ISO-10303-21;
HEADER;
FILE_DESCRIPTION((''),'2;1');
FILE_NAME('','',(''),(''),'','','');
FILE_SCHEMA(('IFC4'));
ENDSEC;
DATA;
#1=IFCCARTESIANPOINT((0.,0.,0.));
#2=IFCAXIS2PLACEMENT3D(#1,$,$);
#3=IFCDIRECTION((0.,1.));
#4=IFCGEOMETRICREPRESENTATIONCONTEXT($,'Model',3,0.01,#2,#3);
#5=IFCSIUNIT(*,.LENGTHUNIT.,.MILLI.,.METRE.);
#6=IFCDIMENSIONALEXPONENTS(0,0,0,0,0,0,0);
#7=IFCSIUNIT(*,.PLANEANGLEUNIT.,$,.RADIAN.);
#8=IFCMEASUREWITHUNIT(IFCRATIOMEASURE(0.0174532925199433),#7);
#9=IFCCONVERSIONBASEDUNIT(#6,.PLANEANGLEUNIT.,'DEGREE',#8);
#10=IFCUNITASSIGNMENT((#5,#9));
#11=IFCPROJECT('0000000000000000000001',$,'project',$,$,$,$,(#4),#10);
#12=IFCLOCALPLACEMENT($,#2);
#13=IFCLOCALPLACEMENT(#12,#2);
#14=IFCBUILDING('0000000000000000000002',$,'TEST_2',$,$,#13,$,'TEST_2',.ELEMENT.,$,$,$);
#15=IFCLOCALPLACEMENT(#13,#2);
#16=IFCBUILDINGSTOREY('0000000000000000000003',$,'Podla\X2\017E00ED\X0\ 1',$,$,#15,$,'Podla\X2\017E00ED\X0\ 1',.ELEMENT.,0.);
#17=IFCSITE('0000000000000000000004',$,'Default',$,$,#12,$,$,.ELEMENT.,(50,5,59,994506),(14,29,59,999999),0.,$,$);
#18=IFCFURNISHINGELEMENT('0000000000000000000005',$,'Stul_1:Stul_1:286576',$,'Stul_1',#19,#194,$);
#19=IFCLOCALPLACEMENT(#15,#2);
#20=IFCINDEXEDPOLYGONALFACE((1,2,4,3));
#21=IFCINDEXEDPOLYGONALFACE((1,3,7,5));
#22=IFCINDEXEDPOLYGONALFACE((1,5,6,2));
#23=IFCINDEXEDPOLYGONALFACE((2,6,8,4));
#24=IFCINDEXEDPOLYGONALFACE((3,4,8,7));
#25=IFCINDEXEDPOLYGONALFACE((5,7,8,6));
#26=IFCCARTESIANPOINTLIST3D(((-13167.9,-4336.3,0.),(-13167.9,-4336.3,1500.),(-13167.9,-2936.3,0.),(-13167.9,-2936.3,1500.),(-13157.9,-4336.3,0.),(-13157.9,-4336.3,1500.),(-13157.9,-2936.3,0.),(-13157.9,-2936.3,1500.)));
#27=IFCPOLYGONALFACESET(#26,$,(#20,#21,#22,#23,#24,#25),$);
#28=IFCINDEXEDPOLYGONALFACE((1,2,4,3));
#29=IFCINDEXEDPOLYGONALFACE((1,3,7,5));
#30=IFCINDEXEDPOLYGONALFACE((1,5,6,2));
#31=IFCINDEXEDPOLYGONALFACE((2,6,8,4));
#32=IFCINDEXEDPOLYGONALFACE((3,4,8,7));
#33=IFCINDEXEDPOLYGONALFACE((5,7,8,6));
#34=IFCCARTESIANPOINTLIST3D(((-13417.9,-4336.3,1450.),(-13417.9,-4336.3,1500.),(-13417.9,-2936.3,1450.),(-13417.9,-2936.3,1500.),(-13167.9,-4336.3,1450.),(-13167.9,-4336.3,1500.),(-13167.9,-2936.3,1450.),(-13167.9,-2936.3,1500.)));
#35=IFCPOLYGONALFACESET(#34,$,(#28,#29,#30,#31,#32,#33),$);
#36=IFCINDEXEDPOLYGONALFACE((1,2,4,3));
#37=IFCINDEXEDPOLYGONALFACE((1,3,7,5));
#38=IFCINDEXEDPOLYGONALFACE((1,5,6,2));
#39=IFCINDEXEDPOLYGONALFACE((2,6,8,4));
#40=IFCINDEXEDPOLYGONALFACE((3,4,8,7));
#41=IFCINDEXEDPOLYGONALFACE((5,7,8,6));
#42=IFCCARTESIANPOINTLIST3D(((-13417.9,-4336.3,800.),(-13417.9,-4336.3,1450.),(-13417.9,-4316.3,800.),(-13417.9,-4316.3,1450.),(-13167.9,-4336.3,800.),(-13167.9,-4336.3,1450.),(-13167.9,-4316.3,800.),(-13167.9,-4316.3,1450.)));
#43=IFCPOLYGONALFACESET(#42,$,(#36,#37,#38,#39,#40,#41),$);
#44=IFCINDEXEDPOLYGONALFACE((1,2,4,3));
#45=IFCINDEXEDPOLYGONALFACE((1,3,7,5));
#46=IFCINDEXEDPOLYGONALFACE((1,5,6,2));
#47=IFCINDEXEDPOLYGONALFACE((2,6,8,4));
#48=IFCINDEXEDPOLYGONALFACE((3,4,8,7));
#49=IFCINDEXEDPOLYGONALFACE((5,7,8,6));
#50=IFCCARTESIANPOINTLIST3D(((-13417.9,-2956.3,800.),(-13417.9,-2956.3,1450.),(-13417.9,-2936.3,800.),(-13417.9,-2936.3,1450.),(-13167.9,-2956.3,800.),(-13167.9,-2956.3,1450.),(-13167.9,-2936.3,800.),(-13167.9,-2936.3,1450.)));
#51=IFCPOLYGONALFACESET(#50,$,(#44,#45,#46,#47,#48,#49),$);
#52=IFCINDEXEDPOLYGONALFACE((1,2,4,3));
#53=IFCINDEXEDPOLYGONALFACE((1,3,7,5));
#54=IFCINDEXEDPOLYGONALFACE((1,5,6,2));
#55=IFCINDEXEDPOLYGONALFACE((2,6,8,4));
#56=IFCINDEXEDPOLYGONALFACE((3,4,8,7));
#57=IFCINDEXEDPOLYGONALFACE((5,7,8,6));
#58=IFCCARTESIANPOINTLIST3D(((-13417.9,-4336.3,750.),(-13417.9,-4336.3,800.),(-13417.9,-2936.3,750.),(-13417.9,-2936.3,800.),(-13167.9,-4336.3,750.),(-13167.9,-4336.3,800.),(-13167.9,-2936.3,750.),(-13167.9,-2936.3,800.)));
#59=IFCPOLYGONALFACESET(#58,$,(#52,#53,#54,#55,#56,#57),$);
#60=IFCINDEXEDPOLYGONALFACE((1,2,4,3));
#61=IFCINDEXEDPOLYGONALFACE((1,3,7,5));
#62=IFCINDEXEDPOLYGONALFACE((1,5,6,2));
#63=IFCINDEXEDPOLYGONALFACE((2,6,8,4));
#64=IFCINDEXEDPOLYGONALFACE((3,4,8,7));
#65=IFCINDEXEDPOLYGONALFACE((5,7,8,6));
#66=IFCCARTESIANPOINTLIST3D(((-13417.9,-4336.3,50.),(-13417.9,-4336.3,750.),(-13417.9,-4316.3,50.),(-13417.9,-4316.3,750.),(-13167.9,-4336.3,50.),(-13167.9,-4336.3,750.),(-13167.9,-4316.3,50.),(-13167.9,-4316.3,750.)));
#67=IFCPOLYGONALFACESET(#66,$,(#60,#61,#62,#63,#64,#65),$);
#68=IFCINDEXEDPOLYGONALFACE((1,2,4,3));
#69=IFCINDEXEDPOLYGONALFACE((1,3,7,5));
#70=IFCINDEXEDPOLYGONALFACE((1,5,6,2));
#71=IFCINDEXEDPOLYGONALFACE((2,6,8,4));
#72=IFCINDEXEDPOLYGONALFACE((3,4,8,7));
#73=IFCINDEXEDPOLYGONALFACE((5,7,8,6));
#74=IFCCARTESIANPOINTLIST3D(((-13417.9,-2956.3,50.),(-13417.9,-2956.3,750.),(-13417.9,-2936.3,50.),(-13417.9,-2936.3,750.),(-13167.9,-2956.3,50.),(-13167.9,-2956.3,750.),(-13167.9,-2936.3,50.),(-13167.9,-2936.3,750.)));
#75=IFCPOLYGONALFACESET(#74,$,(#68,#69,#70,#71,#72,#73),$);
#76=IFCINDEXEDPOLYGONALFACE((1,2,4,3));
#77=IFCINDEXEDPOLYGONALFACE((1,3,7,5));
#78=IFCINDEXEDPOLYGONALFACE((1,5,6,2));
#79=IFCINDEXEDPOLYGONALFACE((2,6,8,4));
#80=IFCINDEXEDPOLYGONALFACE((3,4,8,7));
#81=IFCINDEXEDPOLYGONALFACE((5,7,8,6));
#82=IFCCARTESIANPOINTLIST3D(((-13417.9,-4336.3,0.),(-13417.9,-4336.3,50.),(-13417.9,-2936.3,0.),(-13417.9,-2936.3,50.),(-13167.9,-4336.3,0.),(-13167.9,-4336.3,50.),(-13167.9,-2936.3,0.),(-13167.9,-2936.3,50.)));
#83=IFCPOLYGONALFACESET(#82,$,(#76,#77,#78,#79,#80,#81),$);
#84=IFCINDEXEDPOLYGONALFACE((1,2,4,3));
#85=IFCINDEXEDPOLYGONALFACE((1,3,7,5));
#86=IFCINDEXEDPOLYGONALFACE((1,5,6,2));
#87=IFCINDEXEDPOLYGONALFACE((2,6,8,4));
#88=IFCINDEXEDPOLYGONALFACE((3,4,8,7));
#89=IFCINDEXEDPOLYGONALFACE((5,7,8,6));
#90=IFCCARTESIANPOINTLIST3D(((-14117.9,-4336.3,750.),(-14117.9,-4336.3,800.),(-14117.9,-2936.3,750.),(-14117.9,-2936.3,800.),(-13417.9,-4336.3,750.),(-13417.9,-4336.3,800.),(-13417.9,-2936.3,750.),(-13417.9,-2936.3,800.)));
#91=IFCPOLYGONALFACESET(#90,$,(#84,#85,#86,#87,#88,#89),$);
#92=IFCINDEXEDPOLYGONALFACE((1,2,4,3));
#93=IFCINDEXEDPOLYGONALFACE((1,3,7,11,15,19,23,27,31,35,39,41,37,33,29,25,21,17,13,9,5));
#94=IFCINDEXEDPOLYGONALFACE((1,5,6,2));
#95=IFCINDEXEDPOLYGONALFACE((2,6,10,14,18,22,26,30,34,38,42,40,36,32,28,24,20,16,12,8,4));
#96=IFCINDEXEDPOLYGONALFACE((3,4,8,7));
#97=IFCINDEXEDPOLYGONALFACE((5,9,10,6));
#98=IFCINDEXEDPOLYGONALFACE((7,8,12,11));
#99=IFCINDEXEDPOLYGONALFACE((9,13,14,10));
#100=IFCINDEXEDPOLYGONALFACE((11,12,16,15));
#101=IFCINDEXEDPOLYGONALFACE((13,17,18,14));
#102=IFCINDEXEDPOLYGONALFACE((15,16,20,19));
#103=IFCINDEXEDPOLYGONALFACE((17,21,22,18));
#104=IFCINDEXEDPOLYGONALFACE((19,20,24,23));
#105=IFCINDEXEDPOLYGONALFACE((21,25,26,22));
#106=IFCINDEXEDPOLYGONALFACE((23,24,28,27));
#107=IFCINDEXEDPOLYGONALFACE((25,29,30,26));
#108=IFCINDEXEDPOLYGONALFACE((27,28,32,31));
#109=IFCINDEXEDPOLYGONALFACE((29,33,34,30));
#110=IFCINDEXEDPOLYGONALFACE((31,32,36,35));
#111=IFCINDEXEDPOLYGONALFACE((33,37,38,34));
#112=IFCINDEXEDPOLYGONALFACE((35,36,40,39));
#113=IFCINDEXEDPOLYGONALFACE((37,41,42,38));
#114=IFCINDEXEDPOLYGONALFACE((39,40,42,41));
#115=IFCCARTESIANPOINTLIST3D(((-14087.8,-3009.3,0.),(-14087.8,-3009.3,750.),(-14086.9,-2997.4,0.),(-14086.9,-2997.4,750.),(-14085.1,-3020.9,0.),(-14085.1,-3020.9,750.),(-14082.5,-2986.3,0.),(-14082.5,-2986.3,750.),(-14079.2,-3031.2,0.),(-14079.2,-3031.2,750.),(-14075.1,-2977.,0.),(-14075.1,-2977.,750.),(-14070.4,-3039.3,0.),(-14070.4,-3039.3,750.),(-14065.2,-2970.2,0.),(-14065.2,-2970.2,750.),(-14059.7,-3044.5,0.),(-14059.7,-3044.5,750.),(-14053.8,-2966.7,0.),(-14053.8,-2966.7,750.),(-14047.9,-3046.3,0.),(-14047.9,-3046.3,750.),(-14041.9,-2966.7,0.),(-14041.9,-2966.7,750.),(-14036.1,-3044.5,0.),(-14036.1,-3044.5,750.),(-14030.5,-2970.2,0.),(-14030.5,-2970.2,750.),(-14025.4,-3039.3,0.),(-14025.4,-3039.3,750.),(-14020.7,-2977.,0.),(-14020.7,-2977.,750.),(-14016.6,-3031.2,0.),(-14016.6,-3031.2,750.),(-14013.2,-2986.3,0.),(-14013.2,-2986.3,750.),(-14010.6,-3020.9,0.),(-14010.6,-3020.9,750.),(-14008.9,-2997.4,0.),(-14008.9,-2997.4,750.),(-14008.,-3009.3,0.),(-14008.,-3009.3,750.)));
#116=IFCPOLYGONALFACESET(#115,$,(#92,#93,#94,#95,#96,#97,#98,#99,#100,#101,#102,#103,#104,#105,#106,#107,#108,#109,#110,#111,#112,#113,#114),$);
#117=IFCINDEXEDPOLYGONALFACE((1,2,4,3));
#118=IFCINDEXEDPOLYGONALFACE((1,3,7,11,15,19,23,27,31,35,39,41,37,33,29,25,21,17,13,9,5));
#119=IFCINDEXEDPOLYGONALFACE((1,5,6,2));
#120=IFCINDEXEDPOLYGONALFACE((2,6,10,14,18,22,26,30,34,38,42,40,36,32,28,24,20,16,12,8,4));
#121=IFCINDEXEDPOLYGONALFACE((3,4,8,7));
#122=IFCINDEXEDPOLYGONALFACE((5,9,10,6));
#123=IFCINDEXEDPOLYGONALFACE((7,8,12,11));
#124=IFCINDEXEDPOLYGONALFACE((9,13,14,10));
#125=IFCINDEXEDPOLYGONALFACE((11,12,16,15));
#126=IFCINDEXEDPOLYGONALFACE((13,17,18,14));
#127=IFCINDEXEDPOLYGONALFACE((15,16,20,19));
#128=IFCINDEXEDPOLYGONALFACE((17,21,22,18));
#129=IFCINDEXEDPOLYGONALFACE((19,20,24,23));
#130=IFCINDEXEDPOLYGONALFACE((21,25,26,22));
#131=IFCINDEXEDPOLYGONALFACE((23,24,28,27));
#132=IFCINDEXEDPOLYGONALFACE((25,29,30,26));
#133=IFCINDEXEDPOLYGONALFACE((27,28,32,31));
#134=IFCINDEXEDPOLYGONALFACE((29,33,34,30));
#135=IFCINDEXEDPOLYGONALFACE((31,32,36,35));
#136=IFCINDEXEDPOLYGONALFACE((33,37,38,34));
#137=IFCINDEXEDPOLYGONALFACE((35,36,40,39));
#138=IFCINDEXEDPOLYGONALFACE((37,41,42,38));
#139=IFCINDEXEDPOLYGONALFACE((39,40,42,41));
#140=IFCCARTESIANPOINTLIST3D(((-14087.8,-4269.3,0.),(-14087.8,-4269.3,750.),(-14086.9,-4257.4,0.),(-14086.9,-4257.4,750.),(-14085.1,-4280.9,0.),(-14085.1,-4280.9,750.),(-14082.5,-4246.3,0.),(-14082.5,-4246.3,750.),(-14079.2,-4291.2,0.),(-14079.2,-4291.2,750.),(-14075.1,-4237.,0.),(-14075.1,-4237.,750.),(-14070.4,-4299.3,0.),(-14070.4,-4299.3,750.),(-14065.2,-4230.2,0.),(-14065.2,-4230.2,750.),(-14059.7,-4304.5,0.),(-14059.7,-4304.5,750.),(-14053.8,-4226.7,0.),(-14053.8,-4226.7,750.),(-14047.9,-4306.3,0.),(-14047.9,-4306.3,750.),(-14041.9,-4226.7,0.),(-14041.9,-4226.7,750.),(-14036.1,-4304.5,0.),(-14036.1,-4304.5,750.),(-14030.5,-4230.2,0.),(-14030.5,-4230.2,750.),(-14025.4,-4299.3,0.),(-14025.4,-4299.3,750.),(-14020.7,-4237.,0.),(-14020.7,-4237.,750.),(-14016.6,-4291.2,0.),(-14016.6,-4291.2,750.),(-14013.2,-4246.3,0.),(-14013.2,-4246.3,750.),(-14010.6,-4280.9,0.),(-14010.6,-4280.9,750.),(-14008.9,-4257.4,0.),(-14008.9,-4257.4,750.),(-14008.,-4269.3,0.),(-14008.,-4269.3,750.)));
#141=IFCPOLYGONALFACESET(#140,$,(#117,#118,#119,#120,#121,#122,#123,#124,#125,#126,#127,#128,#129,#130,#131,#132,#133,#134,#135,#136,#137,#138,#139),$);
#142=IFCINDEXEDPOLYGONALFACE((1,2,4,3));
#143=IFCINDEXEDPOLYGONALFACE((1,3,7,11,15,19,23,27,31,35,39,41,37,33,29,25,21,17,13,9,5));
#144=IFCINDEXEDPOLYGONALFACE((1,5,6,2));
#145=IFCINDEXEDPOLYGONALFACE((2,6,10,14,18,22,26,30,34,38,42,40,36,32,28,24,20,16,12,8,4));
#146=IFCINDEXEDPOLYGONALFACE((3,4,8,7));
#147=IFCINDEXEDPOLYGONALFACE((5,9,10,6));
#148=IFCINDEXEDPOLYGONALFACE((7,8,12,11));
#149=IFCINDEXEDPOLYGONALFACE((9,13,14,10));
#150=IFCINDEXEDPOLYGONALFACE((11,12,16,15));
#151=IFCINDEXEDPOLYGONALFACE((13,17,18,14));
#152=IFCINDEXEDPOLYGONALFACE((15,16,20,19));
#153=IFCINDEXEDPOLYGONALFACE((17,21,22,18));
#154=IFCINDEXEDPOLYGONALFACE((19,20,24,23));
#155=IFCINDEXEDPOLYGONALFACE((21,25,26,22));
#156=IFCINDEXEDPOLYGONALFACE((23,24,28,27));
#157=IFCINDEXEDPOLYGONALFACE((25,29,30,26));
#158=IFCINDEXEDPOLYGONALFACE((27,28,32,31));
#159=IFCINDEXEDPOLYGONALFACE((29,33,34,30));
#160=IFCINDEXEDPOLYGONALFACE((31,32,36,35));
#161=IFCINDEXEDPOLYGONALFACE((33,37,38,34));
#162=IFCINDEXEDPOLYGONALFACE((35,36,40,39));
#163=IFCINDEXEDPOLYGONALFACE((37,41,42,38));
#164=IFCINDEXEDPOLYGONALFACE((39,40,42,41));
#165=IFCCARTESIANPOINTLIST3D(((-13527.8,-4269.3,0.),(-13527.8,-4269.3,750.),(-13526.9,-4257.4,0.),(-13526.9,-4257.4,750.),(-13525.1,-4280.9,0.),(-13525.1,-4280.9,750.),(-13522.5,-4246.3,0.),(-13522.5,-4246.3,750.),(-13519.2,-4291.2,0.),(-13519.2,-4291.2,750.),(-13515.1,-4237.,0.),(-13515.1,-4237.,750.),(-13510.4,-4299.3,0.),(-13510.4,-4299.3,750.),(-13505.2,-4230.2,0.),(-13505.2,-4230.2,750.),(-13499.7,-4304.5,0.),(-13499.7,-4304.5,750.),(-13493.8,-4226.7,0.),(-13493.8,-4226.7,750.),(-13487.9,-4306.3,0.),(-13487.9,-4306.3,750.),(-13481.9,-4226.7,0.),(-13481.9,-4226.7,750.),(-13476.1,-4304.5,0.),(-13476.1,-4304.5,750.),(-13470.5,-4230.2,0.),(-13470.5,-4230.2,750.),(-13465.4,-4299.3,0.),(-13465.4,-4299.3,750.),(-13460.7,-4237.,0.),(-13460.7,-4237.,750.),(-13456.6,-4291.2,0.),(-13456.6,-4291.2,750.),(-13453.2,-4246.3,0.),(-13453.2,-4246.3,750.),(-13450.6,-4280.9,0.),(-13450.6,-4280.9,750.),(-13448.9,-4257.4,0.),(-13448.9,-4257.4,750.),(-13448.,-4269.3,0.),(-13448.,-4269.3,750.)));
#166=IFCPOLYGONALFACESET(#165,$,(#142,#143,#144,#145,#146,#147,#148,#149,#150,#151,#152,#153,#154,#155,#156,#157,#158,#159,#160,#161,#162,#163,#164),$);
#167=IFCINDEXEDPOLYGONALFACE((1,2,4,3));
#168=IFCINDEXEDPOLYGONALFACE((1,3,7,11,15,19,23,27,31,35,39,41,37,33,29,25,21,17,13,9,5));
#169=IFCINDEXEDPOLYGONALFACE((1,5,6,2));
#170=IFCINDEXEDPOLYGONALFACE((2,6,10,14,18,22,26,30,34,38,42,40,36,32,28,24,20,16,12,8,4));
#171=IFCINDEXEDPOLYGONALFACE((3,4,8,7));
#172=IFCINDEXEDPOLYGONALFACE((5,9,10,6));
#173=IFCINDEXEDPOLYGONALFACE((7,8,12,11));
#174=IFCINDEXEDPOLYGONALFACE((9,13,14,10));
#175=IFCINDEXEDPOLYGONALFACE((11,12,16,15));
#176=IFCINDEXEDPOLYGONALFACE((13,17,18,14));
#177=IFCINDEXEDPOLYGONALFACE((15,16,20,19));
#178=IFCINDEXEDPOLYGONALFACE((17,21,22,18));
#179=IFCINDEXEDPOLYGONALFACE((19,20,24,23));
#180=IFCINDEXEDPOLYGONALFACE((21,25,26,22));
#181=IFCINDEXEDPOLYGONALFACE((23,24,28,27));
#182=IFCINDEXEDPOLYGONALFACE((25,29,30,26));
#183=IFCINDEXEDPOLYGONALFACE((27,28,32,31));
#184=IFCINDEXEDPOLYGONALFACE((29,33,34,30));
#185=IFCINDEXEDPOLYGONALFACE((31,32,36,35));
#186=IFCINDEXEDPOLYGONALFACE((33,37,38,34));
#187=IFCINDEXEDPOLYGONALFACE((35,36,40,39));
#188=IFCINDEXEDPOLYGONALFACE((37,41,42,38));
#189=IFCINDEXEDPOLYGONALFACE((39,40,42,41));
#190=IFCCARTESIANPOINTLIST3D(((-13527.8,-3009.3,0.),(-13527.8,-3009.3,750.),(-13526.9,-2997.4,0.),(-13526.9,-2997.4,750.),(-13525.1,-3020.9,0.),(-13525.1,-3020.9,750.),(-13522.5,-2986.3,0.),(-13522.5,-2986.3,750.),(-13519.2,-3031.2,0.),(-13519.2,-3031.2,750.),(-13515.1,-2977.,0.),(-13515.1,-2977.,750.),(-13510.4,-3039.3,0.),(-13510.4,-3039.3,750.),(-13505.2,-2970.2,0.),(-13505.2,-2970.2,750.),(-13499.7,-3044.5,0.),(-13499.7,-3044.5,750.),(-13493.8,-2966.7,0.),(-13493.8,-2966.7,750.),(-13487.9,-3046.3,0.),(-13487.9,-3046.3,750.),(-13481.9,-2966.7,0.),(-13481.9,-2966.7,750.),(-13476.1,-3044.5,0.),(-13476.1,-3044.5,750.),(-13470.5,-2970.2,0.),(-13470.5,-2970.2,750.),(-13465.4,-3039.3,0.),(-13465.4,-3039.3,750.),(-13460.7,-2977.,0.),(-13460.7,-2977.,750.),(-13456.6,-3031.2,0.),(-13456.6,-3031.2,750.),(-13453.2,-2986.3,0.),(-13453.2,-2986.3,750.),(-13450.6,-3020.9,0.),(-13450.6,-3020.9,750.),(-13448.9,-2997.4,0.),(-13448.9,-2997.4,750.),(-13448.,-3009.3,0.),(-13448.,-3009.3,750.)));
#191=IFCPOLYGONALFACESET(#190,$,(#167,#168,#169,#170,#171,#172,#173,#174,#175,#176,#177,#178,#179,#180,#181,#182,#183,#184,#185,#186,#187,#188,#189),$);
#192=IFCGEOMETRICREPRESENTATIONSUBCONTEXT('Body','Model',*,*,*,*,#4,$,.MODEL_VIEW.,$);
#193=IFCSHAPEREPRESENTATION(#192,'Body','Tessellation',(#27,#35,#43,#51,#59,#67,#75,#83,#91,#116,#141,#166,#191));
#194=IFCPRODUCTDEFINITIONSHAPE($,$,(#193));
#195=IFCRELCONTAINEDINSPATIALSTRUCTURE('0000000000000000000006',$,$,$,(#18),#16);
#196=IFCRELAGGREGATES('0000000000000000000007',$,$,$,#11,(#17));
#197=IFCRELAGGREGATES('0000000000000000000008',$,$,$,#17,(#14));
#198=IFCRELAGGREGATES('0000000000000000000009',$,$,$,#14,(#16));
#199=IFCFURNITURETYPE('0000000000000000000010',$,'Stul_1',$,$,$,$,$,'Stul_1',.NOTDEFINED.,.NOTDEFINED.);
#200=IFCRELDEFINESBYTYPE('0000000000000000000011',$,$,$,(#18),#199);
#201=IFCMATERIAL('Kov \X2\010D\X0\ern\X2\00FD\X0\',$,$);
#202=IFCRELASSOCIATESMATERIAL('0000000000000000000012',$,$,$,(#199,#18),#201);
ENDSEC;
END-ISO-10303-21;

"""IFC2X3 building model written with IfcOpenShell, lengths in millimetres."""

from ifc_helpers import new_model, entity, si_unit, converted_unit, direction, frame, frame_2d, origin, origin_2d_with_axis, place, context, subcontext, project, spatial, rectangle, circle, extrude, source, transform, mapped, material, type_object, type_shapes, element, save


model = new_model("IFC2X3")

# Units and contexts
model_context = context("Model", 3, precision=0.01, world=origin(), true_north=direction((0.0, 1.0)))
body_context = subcontext(model_context, "Body", "Model", "MODEL_VIEW")
ifc_project = project(units=[si_unit("LENGTHUNIT", "METRE", prefix="MILLI"), converted_unit("PLANEANGLEUNIT", "DEGREE", entity("IfcRatioMeasure", 0.0174532925199433), si_unit("PLANEANGLEUNIT", "RADIAN"), dimensions=[0, 0, 0, 0, 0, 0, 0])], contexts=[model_context])

# Site, building, storey
site_placement = place(None, origin())
site = spatial("IfcSite", under=ifc_project, at=site_placement, Name="Default", CompositionType="ELEMENT", RefLatitude=(50, 5, 59, 994506), RefLongitude=(14, 29, 59, 999999), RefElevation=0.0)
building_placement = place(site_placement, origin())
building = spatial("IfcBuilding", under=site, at=building_placement, Name="TEST_2", LongName="TEST_2", CompositionType="ELEMENT")
storey_placement = place(building_placement, origin())
storey = spatial("IfcBuildingStorey", under=building, at=storey_placement, Name="Podlaží 1", LongName="Podlaží 1", CompositionType="ELEMENT", Elevation=0.0)

# Furnishing element
ifc_material_1 = material(Name="Kov černý")
furniture_type = type_object("IfcFurnitureType", Name="Stul_1", ElementType="Stul_1", material=ifc_material_1)
shared_shape_1 = source(origin(), body_context, "Body", "SweptSolid", [
    extrude(rectangle(XDim=1400.0, YDim=10.0, at=origin_2d_with_axis()), frame((0.0, 605.0, 0.0), z_axis=(0.0, 0.0, 1.0), x_axis=(-1.0, 0.0, 0.0)), (0.0, 0.0, 1.0), 1500.0),
    extrude(rectangle(XDim=1400.0, YDim=250.0, at=frame_2d((0.0, 0.0), x_axis=(1.0, 0.0))), frame((0.0, 475.0, 1450.0), z_axis=(0.0, 0.0, 1.0), x_axis=(-1.0, 0.0, 0.0)), (0.0, 0.0, 1.0), 50.0),
    extrude(rectangle(XDim=20.0, YDim=250.0, at=origin_2d_with_axis()), frame((690.0, 475.0, 800.0), z_axis=(0.0, 0.0, 1.0), x_axis=(-1.0, 0.0, 0.0)), (0.0, 0.0, 1.0), 650.0),
    extrude(rectangle(XDim=20.0, YDim=250.0, at=frame_2d((0.0, 0.0), x_axis=(1.0, 0.0))), frame((-690.0, 475.0, 800.0), z_axis=(0.0, 0.0, 1.0), x_axis=(-1.0, 0.0, 0.0)), (0.0, 0.0, 1.0), 650.0),
    extrude(rectangle(XDim=1400.0, YDim=250.0, at=origin_2d_with_axis()), frame((0.0, 475.0, 750.0), z_axis=(0.0, 0.0, 1.0), x_axis=(-1.0, 0.0, 0.0)), (0.0, 0.0, 1.0), 50.0),
    extrude(rectangle(XDim=20.0, YDim=250.0, at=origin_2d_with_axis()), frame((690.0, 475.0, 50.0), z_axis=(0.0, 0.0, 1.0), x_axis=(-1.0, 0.0, 0.0)), (0.0, 0.0, 1.0), 700.0),
    extrude(rectangle(XDim=20.0, YDim=250.0, at=frame_2d((0.0, 0.0), x_axis=(1.0, 0.0))), frame((-690.0, 475.0, 50.0), z_axis=(0.0, 0.0, 1.0), x_axis=(-1.0, 0.0, 0.0)), (0.0, 0.0, 1.0), 700.0),
    extrude(rectangle(XDim=1400.0, YDim=250.0, at=origin_2d_with_axis()), frame((0.0, 475.0, 0.0), z_axis=(0.0, 0.0, 1.0), x_axis=(-1.0, 0.0, 0.0)), (0.0, 0.0, 1.0), 50.0),
    extrude(rectangle(XDim=1400.0, YDim=700.0, at=origin_2d_with_axis()), frame((0.0, 0.0, 750.0), z_axis=(0.0, 0.0, 1.0), x_axis=(-1.0, 0.0, 0.0)), (0.0, 0.0, 1.0), 50.0),
    extrude(circle(Radius=40.0, at=frame_2d((0.0, 0.0), x_axis=(1.0, 0.0))), frame((-630.0, -280.0, 0.0)), (0.0, 0.0, 1.0), 750.0),
    extrude(circle(Radius=40.0, at=frame_2d((0.0, 0.0), x_axis=(1.0, 0.0))), frame((630.0, -280.0, 0.0)), (0.0, 0.0, 1.0), 750.0),
    extrude(circle(Radius=40.0, at=frame_2d((0.0, 0.0), x_axis=(1.0, 0.0))), frame((630.0, 280.0, 0.0)), (0.0, 0.0, 1.0), 750.0),
    extrude(circle(Radius=40.0, at=frame_2d((0.0, 0.0), x_axis=(1.0, 0.0))), frame((-630.0, 280.0, 0.0)), (0.0, 0.0, 1.0), 750.0),
])
type_shapes(furniture_type, [shared_shape_1])
for number, where, z_axis, x_axis, name in (
    (1, (-13767.9, -3636.3, 0.0), (0.0, 0.0, 1.0), (0.0, -1.0, 0.0), "Stul_1:Stul_1:286576"),
):
    element("IfcFurnishingElement", number, at=place(storey_placement, frame(where, z_axis=z_axis, x_axis=x_axis)), inside=storey, type_object=furniture_type, material=ifc_material_1, Name=name, ObjectType="Stul_1", context=body_context, shape_type="MappedRepresentation", body=[
        mapped(shared_shape_1, transform((0.0, 0.0, 0.0), scale=1.0)),
    ])

save(model, "model.ifc")
